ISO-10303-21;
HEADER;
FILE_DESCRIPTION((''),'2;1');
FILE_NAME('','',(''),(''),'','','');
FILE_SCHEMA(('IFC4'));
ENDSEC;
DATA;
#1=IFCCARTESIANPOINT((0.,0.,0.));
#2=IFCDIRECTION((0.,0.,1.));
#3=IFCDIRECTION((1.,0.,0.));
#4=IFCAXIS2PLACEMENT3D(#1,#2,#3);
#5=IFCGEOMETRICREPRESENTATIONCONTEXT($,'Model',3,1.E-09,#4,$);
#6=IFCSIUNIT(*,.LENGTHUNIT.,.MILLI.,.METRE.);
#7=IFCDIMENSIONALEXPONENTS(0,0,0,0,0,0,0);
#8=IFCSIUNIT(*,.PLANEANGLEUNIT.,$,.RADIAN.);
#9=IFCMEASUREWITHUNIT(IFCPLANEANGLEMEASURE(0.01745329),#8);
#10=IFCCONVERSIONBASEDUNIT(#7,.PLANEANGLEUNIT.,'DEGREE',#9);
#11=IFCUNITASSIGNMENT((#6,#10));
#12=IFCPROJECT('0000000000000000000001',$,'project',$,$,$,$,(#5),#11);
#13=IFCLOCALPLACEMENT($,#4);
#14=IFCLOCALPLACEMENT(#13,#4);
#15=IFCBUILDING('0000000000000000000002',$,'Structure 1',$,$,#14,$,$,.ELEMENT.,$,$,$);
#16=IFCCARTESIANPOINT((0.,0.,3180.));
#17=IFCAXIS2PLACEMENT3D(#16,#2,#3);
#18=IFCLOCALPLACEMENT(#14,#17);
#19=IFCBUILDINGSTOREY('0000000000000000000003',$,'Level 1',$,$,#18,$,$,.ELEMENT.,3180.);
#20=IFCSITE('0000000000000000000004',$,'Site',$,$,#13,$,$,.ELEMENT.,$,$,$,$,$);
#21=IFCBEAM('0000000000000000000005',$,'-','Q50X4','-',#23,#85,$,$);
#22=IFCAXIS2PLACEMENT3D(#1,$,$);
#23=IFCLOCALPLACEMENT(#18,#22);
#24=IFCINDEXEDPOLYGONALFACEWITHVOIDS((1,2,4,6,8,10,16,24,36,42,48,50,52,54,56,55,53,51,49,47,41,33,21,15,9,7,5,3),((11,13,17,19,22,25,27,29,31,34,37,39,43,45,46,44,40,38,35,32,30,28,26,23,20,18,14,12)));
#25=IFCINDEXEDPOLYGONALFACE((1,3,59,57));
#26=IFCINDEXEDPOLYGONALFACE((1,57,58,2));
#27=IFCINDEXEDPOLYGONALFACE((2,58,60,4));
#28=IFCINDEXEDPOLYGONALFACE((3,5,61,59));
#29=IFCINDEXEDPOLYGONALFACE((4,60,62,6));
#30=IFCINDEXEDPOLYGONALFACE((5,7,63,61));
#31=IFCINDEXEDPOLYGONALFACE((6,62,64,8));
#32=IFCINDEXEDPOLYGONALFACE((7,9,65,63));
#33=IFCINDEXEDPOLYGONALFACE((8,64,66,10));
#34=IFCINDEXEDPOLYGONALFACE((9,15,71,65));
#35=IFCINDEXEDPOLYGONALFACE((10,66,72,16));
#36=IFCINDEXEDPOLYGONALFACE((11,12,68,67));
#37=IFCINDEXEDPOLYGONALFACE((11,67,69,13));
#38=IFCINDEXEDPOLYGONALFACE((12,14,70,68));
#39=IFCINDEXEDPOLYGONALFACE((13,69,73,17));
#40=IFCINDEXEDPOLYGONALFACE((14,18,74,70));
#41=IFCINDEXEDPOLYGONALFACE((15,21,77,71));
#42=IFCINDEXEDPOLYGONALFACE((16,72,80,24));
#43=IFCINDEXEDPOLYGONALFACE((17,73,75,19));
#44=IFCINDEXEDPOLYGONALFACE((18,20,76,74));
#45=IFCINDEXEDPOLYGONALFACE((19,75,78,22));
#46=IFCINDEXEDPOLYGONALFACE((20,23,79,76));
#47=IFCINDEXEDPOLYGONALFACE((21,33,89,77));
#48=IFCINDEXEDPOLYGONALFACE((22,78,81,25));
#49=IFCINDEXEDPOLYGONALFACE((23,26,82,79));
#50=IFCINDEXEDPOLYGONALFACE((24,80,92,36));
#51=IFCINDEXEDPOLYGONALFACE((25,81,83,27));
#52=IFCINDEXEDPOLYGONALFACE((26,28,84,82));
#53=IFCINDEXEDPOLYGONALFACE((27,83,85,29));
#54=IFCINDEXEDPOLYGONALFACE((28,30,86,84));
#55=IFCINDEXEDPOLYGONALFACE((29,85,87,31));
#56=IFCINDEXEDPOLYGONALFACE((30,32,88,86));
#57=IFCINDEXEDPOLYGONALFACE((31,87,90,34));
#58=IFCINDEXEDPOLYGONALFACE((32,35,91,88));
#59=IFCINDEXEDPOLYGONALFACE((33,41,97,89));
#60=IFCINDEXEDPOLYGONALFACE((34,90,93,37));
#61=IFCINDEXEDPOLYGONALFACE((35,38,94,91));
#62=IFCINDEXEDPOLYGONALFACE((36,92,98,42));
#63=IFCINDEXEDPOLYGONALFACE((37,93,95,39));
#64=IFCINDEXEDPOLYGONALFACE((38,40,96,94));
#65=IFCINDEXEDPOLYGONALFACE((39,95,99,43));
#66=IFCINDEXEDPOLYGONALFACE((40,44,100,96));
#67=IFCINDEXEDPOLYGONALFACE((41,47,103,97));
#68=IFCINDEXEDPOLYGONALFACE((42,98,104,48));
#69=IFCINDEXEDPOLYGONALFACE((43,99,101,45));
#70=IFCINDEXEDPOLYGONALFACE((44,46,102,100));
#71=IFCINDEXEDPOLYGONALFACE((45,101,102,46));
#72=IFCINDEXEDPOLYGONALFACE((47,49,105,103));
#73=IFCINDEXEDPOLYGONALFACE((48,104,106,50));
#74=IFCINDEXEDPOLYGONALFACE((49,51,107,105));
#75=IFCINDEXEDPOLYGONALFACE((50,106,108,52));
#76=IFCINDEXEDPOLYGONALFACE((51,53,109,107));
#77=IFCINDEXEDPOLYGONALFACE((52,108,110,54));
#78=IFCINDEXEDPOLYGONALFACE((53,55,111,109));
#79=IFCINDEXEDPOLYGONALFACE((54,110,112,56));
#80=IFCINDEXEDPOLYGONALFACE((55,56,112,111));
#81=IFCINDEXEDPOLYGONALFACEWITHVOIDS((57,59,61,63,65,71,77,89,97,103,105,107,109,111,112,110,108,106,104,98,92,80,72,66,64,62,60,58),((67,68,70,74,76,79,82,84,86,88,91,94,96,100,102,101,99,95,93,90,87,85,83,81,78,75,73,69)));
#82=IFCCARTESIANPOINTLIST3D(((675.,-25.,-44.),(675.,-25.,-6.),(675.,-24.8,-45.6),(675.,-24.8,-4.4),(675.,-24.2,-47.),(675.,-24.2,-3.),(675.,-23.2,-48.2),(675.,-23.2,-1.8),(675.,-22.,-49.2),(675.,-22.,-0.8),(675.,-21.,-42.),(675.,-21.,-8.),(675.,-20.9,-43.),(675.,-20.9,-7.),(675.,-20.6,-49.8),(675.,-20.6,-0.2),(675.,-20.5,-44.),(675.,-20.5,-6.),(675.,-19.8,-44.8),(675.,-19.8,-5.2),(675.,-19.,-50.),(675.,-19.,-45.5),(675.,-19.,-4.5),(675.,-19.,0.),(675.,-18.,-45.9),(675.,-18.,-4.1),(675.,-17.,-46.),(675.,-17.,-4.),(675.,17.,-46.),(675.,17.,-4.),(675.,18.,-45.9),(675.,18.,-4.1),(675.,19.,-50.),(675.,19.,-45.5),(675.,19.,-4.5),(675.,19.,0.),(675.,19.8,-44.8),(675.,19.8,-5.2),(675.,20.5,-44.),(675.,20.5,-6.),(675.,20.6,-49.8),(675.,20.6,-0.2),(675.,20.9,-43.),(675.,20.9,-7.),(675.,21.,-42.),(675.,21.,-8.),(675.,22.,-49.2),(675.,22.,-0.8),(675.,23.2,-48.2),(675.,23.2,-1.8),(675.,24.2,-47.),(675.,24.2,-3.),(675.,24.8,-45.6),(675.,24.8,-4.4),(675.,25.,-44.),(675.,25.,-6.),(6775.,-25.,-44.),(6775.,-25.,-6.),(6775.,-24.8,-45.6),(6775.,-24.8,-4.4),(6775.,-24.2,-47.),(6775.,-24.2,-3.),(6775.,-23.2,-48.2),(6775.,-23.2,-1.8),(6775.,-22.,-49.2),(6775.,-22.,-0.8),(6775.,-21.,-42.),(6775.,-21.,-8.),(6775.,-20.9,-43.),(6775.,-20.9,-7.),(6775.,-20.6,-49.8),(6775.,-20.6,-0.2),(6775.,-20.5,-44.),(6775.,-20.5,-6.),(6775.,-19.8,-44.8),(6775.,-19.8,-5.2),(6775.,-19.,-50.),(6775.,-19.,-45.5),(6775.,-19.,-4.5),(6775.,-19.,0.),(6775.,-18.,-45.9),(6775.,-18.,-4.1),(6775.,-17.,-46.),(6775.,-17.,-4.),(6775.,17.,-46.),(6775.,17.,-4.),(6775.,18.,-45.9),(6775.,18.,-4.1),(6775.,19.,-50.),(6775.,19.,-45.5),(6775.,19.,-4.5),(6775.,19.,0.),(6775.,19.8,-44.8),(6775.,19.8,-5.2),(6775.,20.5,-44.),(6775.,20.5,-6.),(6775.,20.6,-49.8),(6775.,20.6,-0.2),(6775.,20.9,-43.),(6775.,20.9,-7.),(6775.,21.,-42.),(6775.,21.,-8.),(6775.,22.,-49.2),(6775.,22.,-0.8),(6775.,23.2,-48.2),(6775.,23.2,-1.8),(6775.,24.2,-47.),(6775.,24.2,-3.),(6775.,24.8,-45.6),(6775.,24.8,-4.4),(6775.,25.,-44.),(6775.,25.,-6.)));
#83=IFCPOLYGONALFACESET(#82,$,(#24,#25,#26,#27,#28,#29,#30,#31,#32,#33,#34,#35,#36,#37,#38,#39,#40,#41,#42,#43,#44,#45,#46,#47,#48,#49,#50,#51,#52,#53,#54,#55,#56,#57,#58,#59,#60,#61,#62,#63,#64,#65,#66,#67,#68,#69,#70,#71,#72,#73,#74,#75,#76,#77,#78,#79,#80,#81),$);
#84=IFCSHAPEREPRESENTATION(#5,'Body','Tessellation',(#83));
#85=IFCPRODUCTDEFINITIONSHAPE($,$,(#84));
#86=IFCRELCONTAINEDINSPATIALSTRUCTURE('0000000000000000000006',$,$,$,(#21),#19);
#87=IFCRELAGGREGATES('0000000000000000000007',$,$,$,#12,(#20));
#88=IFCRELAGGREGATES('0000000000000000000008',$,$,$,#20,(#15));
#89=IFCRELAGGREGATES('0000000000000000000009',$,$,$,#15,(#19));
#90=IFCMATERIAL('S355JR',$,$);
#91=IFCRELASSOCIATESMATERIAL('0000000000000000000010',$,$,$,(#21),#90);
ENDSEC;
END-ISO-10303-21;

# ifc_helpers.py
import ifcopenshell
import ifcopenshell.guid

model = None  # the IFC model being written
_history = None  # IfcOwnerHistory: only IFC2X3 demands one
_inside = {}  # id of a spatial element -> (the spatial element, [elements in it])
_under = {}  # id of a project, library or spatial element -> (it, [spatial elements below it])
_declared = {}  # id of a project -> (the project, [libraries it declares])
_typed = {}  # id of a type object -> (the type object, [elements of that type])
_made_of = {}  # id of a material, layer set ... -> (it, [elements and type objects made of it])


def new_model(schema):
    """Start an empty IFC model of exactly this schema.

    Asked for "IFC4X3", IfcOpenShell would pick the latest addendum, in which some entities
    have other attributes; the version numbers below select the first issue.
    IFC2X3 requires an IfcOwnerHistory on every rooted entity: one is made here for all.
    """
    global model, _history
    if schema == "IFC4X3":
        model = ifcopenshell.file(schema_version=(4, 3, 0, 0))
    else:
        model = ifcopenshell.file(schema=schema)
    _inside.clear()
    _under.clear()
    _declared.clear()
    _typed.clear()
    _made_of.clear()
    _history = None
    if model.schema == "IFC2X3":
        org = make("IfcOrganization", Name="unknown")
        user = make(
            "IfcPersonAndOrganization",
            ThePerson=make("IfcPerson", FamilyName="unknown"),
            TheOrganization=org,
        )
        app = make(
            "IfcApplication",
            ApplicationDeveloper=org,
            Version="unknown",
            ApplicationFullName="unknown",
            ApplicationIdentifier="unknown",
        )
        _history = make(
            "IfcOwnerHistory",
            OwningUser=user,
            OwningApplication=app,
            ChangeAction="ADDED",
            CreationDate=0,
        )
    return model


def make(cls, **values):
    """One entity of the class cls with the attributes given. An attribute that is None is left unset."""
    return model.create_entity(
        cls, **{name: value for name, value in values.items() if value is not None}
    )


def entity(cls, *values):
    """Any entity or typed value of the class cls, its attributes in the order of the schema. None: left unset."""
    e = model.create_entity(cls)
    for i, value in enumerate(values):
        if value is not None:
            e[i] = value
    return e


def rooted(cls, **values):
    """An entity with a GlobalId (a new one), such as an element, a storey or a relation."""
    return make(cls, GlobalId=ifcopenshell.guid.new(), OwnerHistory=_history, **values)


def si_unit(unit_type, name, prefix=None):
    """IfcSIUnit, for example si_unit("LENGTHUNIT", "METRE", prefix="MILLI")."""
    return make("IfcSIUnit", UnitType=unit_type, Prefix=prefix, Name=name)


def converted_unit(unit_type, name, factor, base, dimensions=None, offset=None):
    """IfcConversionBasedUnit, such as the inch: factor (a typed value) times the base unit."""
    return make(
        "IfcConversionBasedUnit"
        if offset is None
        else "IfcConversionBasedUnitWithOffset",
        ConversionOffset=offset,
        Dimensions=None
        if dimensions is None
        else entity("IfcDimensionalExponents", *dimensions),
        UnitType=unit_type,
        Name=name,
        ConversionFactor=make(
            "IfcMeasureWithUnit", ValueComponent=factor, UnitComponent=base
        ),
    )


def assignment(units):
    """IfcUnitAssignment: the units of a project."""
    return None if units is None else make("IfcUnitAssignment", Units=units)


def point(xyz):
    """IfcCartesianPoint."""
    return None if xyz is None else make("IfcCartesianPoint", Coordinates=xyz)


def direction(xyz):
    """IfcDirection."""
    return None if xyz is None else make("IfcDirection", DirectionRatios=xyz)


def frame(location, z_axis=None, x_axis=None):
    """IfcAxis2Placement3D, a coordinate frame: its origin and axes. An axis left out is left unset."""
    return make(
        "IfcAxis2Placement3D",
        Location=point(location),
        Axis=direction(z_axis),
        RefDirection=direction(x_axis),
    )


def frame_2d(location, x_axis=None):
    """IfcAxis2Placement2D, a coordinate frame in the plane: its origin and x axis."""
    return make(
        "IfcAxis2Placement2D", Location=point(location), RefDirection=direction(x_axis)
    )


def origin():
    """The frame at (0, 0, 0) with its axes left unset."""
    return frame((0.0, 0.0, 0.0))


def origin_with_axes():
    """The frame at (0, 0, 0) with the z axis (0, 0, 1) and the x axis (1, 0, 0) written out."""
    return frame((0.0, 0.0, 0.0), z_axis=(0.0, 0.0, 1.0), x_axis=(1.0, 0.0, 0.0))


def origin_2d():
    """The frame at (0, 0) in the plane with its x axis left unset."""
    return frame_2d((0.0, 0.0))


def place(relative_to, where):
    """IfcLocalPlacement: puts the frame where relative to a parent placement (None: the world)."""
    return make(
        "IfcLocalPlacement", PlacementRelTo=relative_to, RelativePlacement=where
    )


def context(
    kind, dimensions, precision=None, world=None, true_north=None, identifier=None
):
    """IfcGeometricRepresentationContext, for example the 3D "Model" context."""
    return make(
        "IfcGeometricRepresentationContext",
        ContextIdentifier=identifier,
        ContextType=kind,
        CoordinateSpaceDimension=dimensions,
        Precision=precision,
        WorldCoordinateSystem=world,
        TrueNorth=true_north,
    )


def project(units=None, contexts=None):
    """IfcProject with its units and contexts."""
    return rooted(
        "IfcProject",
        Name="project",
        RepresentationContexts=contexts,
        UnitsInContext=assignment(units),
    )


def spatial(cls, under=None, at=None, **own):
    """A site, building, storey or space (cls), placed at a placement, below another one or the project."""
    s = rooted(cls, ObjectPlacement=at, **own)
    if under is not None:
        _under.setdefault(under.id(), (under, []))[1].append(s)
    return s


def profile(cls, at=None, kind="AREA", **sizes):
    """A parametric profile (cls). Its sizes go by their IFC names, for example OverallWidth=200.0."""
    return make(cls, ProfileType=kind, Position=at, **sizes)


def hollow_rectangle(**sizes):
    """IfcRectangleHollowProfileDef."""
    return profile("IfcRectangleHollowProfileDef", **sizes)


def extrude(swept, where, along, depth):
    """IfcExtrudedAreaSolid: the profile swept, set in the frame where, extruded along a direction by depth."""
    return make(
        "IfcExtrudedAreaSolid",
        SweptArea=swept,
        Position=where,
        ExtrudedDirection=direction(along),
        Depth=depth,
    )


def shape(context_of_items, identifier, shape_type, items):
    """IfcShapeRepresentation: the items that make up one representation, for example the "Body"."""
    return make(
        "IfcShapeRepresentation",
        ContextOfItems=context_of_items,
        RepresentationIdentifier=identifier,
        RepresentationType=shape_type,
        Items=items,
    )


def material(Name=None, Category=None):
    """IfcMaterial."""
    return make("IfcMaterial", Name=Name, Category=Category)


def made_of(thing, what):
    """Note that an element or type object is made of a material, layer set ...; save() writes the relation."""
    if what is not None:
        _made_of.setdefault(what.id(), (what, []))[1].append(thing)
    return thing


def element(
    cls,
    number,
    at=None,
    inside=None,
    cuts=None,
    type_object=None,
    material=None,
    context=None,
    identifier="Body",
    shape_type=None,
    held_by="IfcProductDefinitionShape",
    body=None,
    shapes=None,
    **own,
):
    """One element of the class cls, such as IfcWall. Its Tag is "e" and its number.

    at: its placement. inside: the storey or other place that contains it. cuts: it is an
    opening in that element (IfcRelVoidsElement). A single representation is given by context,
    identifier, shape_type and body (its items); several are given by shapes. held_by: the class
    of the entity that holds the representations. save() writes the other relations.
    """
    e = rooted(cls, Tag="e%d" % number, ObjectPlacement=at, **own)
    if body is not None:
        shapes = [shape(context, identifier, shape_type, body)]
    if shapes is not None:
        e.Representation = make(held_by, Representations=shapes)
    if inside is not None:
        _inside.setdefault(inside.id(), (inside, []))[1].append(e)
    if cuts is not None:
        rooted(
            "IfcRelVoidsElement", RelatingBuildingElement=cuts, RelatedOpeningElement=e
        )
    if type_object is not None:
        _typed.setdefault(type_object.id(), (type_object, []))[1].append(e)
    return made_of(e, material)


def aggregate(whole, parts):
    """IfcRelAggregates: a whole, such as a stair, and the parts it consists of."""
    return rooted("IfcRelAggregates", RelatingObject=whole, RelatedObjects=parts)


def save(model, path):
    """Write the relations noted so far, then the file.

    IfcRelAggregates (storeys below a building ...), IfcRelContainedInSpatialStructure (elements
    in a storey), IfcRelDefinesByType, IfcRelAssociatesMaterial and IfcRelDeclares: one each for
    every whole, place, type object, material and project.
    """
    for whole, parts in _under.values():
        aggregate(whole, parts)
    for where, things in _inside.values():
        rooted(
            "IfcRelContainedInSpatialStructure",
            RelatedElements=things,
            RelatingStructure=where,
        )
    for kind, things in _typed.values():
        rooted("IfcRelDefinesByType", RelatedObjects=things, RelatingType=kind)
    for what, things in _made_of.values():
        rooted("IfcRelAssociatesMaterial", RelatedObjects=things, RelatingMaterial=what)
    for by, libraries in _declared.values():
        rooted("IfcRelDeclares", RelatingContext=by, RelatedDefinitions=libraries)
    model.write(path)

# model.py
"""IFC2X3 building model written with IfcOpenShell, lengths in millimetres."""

from ifc_helpers import new_model, entity, si_unit, converted_unit, frame, origin, origin_with_axes, origin_2d, place, context, project, spatial, hollow_rectangle, extrude, material, element, save


model = new_model("IFC2X3")

# Units and contexts
model_context = context("Model", 3, precision=1e-09, world=origin_with_axes())
ifc_project = project(units=[si_unit("LENGTHUNIT", "METRE", prefix="MILLI"), converted_unit("PLANEANGLEUNIT", "DEGREE", entity("IfcPlaneAngleMeasure", 0.01745329), si_unit("PLANEANGLEUNIT", "RADIAN"), dimensions=[0, 0, 0, 0, 0, 0, 0])], contexts=[model_context])

# Site, building, storey
site_placement = place(None, origin_with_axes())
site = spatial("IfcSite", under=ifc_project, at=site_placement, Name="Site", CompositionType="ELEMENT")
building_placement = place(site_placement, origin_with_axes())
building = spatial("IfcBuilding", under=site, at=building_placement, Name="Structure 1", CompositionType="ELEMENT")
storey_placement = place(building_placement, frame((0.0, 0.0, 3180.0), z_axis=(0.0, 0.0, 1.0), x_axis=(1.0, 0.0, 0.0)))
storey = spatial("IfcBuildingStorey", under=building, at=storey_placement, Name="Level 1", CompositionType="ELEMENT", Elevation=3180.0)

# Shared definitions
ifc_material = material(Name="S355JR")

# Beam
beam_1_placement = place(None, frame((675.0, 0.0, 3155.0), z_axis=(-1.0, 0.0, 0.0), x_axis=(0.0, -1.0, 0.0)))
element("IfcBeam", 1, at=beam_1_placement, inside=storey, material=ifc_material, Name="-", Description="Q50X4", ObjectType="-", context=model_context, shape_type="SweptSolid", body=[
    extrude(hollow_rectangle(XDim=50.0, YDim=50.0, WallThickness=4.0, InnerFilletRadius=4.0, OuterFilletRadius=6.0, at=origin_2d()), origin(), (0.0, 0.0, -1.0), 6100.0),
])

save(model, "model.ifc")
